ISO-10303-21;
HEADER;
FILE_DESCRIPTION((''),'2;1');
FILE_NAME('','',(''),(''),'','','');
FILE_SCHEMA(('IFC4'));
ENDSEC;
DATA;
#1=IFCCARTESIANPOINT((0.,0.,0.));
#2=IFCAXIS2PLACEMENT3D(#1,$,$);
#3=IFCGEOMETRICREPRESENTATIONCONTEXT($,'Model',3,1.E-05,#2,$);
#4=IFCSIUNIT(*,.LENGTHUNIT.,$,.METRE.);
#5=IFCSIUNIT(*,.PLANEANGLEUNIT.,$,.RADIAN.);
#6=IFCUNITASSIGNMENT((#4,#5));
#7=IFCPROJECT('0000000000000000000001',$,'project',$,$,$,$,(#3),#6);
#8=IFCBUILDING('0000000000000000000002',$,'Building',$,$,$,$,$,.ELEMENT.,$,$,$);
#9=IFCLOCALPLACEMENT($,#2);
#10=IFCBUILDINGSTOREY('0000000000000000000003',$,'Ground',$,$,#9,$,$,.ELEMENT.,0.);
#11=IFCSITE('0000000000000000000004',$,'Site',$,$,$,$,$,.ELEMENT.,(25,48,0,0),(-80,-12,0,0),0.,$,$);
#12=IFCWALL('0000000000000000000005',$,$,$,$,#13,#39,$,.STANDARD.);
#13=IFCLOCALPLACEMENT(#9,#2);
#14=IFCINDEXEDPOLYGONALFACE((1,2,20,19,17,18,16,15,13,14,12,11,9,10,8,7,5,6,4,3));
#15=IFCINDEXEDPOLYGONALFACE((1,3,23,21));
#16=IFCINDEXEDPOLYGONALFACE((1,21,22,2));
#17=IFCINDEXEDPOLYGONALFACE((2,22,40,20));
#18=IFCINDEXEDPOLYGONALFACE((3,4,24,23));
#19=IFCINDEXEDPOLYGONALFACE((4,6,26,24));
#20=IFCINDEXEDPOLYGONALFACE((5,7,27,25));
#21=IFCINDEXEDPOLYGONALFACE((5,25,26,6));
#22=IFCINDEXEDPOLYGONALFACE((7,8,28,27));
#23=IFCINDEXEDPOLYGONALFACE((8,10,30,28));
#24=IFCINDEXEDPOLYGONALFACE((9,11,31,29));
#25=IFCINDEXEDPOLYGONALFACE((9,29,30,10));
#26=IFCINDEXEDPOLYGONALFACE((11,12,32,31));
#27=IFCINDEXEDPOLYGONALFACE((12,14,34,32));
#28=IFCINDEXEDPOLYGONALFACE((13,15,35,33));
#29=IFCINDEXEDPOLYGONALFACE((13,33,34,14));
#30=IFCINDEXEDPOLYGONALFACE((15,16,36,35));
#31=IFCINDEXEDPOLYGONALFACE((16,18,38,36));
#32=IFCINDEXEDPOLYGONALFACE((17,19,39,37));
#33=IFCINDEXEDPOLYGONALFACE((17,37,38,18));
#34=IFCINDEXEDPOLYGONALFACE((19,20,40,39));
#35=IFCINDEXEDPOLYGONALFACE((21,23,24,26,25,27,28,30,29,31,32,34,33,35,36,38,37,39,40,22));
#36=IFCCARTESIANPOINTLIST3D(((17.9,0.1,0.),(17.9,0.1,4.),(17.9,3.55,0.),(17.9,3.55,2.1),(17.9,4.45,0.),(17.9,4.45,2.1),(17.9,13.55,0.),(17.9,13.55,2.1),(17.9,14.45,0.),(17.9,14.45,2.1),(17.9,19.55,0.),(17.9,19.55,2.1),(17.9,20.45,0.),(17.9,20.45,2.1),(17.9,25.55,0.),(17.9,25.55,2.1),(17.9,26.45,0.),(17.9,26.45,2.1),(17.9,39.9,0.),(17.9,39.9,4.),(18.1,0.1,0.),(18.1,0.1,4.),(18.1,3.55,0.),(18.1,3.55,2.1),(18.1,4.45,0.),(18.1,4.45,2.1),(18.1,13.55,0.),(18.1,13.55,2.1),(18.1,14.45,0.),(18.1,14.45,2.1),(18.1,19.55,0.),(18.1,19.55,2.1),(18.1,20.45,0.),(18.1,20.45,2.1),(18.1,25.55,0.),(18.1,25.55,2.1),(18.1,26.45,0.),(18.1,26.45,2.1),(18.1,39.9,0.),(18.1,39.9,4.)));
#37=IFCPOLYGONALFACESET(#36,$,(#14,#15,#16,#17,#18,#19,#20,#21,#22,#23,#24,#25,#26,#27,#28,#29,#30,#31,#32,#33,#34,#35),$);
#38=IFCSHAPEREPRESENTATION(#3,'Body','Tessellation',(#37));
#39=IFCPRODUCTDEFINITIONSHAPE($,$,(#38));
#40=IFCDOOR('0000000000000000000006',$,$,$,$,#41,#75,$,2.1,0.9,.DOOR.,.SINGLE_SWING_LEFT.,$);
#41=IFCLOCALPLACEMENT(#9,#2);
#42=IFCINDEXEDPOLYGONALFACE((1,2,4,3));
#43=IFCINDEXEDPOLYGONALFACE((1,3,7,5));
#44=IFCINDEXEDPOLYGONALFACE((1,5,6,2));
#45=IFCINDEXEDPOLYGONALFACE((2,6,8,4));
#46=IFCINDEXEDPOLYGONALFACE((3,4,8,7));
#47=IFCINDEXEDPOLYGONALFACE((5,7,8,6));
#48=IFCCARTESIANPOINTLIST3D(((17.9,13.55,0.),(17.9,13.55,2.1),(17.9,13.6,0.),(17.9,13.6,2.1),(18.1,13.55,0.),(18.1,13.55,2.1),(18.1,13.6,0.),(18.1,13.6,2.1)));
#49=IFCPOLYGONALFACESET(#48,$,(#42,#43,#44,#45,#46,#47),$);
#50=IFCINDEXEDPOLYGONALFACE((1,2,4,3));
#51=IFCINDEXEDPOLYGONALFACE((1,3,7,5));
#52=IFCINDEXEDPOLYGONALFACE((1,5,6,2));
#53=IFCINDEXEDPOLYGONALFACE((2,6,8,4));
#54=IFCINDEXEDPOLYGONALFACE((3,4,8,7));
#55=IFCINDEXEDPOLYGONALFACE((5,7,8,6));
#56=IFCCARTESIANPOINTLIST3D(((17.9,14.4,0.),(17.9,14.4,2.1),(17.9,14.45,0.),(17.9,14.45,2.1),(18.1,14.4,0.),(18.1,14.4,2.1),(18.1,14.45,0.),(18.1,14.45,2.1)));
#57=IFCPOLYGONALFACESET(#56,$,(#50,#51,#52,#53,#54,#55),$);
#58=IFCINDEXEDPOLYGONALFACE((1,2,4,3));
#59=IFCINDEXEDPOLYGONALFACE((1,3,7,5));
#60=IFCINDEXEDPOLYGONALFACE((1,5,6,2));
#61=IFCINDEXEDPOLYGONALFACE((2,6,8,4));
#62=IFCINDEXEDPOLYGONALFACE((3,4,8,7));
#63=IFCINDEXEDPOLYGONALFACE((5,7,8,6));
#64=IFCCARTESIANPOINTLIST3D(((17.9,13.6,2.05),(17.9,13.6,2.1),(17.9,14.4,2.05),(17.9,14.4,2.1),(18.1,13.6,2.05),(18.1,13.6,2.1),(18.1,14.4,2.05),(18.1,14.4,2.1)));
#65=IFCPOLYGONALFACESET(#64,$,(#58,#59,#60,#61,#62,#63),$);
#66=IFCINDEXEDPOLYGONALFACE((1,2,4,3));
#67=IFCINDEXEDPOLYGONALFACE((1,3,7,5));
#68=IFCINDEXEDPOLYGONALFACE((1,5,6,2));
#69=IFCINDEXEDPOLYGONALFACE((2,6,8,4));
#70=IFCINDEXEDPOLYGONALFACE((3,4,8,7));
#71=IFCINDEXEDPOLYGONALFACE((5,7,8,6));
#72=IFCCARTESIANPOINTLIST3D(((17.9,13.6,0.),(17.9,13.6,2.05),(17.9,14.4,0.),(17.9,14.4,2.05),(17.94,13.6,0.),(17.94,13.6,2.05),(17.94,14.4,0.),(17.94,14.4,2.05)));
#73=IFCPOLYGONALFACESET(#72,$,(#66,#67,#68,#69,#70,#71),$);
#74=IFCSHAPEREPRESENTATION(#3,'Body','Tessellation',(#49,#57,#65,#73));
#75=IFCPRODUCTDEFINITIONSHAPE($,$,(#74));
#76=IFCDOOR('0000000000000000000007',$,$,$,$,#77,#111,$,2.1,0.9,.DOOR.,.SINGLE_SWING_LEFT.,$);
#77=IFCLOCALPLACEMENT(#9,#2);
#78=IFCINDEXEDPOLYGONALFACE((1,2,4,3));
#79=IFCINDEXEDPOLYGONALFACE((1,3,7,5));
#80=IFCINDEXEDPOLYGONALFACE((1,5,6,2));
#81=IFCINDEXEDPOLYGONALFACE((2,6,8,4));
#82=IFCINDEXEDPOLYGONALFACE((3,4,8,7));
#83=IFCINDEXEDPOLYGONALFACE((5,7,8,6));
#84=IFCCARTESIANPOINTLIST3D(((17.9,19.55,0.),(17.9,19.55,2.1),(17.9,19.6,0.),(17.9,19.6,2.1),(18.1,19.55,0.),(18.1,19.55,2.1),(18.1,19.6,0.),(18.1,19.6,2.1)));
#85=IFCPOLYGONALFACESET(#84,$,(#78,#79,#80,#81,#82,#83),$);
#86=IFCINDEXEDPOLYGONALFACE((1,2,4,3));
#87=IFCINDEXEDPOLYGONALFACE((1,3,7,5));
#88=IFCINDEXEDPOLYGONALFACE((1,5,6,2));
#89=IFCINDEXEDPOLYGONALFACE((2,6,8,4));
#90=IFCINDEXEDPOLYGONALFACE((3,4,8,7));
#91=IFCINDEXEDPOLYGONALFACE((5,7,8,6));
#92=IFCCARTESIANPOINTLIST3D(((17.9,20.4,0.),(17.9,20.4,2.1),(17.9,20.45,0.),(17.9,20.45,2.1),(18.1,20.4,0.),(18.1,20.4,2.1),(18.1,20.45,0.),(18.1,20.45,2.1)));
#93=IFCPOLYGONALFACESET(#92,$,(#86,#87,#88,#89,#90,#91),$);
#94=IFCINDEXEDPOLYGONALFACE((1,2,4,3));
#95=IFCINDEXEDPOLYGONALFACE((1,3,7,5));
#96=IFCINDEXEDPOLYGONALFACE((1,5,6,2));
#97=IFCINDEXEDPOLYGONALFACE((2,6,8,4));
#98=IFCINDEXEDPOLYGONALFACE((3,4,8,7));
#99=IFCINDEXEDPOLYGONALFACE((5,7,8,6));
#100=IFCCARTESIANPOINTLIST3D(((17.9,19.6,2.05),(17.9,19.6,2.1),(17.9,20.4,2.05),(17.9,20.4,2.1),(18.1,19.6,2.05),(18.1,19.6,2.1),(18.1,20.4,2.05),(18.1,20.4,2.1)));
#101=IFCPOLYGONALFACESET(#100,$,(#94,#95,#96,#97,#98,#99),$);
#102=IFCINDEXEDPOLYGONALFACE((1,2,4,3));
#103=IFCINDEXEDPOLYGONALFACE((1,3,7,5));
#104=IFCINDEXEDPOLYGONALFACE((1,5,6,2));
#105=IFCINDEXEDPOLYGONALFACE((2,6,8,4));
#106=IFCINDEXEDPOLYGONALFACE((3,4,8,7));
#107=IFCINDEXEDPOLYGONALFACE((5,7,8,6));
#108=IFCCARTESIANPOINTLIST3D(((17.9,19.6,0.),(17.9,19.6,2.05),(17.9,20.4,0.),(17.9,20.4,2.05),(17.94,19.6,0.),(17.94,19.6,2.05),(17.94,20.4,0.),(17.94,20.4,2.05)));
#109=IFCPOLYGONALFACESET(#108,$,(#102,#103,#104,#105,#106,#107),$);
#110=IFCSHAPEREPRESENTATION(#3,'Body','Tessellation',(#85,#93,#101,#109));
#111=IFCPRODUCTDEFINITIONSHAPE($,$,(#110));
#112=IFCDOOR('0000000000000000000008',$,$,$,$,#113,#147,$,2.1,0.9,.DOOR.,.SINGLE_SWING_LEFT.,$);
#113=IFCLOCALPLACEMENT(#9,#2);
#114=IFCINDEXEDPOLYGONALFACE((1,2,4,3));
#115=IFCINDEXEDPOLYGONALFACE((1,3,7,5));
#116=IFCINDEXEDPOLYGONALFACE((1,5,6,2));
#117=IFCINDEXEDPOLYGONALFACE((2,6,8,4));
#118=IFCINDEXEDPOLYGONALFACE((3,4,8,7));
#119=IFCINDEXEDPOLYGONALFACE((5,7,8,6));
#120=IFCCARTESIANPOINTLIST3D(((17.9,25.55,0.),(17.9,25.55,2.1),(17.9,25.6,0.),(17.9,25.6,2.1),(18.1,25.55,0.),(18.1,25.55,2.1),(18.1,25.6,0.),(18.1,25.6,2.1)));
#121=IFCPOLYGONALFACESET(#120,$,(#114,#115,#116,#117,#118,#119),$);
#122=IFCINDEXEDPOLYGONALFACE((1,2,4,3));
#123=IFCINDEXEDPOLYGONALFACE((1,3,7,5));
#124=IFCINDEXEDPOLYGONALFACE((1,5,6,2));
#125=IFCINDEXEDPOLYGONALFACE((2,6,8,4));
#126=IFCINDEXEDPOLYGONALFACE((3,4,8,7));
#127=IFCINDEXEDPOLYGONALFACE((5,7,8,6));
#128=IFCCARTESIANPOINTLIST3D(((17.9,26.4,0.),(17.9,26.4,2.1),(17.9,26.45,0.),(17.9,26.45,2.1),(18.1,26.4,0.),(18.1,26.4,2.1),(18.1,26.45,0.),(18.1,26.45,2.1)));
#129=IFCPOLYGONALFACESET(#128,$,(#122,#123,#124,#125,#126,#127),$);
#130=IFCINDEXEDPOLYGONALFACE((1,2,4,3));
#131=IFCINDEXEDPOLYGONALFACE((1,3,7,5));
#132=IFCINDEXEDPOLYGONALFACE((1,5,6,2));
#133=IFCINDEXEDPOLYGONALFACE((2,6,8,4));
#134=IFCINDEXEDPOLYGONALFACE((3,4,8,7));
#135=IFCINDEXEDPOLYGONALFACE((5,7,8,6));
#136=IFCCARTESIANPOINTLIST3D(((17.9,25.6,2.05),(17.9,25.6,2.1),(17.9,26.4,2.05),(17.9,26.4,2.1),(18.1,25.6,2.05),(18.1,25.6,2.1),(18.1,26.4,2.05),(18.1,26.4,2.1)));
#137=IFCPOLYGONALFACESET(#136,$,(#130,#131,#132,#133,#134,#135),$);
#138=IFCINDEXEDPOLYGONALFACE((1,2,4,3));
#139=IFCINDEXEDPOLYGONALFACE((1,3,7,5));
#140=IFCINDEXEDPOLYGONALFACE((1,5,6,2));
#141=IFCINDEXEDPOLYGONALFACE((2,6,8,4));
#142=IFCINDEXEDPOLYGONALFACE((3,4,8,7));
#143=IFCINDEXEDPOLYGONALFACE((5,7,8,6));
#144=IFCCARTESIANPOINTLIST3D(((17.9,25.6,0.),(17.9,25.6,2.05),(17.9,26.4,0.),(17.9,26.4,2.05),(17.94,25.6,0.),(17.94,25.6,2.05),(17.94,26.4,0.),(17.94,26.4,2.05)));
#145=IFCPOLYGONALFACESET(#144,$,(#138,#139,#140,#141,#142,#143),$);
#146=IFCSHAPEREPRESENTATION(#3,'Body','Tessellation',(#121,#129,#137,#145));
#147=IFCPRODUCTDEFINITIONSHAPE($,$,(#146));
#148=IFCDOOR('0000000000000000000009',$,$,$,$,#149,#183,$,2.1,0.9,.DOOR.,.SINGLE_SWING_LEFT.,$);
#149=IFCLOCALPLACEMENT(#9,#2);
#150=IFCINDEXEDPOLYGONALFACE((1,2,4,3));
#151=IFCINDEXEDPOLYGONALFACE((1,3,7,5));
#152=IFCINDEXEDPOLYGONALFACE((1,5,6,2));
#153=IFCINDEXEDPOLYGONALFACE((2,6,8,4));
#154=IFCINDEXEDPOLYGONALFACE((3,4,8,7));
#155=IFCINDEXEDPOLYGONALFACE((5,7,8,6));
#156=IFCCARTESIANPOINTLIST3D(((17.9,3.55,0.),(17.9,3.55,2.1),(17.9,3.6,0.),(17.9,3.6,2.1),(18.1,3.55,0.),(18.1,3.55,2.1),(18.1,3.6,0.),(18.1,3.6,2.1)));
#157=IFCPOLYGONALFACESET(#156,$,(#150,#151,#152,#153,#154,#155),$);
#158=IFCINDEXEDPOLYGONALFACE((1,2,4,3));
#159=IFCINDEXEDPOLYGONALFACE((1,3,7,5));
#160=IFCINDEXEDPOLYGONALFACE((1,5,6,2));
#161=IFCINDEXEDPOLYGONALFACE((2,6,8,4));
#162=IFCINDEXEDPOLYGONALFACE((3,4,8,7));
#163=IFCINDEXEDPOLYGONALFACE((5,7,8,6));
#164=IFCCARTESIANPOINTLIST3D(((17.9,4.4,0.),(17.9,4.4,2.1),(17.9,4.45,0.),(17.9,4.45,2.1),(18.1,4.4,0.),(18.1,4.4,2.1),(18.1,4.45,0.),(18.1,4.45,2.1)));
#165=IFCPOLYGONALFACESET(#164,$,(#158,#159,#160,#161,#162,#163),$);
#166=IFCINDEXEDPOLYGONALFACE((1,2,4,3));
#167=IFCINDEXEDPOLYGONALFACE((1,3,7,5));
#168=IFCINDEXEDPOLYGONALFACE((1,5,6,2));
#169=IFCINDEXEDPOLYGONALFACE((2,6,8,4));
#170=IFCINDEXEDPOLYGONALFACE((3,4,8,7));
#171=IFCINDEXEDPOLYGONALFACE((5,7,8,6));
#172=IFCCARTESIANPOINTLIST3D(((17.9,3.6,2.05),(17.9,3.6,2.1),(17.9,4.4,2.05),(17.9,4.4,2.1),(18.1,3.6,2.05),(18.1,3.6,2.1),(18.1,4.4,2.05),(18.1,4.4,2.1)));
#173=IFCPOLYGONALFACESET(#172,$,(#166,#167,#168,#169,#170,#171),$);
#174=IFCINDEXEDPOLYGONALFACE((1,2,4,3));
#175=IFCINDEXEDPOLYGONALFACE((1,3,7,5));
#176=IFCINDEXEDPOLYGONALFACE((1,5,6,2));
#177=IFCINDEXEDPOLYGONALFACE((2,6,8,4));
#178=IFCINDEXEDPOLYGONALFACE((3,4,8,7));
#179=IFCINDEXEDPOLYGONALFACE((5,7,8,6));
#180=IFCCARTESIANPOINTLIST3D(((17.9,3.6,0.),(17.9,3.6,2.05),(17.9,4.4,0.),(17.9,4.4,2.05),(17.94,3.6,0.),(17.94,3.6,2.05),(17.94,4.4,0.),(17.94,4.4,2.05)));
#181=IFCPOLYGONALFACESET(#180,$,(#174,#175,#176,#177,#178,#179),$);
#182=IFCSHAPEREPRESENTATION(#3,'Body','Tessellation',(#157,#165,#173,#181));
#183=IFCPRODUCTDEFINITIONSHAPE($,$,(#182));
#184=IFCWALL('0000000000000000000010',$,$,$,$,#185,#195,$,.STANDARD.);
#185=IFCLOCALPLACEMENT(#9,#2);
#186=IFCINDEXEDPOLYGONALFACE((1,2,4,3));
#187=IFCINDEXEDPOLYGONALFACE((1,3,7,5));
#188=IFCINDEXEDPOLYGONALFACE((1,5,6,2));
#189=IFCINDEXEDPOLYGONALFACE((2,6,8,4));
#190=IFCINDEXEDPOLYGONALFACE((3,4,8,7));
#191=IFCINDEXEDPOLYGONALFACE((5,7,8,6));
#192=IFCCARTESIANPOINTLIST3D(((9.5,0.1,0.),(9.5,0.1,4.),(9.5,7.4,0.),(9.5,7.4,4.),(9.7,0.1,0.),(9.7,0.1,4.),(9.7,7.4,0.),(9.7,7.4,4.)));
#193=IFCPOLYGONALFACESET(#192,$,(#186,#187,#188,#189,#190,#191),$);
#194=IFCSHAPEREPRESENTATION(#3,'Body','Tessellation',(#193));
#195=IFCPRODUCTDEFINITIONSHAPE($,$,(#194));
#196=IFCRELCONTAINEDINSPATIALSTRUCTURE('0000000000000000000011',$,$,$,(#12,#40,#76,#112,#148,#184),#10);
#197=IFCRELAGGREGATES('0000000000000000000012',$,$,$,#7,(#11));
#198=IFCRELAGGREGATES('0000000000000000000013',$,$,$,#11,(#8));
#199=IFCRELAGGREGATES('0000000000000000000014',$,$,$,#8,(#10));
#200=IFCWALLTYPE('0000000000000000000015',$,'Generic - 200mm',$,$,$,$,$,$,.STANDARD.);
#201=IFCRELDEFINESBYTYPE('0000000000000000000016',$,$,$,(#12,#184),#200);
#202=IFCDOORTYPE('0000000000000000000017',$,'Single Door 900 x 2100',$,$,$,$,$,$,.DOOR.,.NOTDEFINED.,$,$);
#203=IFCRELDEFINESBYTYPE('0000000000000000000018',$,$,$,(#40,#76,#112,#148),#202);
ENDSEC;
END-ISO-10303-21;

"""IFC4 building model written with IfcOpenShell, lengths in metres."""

from ifc_helpers import new_model, si_unit, frame, frame_2d, origin, origin_with_axes, origin_2d, place, context, project, spatial, polyline, rectangle, outline, extrude, type_object, element, fill, save


model = new_model("IFC4")

# Units and contexts
model_context = context("Model", 3, precision=1e-05, world=origin())
ifc_project = project(units=[si_unit("LENGTHUNIT", "METRE"), si_unit("PLANEANGLEUNIT", "RADIAN")], contexts=[model_context])

# Site, building, storey
site = spatial("IfcSite", under=ifc_project, Name="Site", CompositionType="ELEMENT", RefLatitude=(25, 48, 0, 0), RefLongitude=(-80, -12, 0, 0), RefElevation=0.0)
building = spatial("IfcBuilding", under=site, Name="Building", CompositionType="ELEMENT")
storey_placement = place(None, origin())
storey = spatial("IfcBuildingStorey", under=building, at=storey_placement, Name="Ground", CompositionType="ELEMENT", Elevation=0.0)

# Wall, openings, doors
wall_type_1 = type_object("IfcWallType", Name="Generic - 200mm", PredefinedType="STANDARD")
door_type = type_object("IfcDoorType", Name="Single Door 900 x 2100", OperationType="NOTDEFINED", PredefinedType="DOOR")
wall_1_placement = place(None, frame((18.0, 0.0, 0.0), z_axis=(0.0, 0.0, 1.0), x_axis=(0.0, 1.0, 0.0)))
wall_1 = element("IfcWall", 1, at=wall_1_placement, inside=storey, type_object=wall_type_1, PredefinedType="STANDARD", context=model_context, shape_type="SweptSolid", body=[
    extrude(outline(polyline([(0.1, -0.1), (39.9, -0.1), (39.9, 0.1), (0.1, 0.1), (0.1, -0.1)])), origin(), (0.0, 0.0, 1.0), 4.0),
])
opening_1_placement = place(wall_1_placement, frame((14.0, 0.0, 0.0), z_axis=(0.0, 0.0, 1.0), x_axis=(1.0, 0.0, 0.0)))
opening_1 = element("IfcOpeningElement", 2, at=opening_1_placement, cuts=wall_1, PredefinedType="OPENING", context=model_context, shape_type="SweptSolid", body=[
    extrude(rectangle(XDim=0.9, YDim=0.202, at=origin_2d()), origin(), (0.0, 0.0, 1.0), 2.1),
])
opening_2_placement = place(wall_1_placement, frame((20.0, 0.0, 0.0), z_axis=(0.0, 0.0, 1.0), x_axis=(1.0, 0.0, 0.0)))
opening_2 = element("IfcOpeningElement", 3, at=opening_2_placement, cuts=wall_1, PredefinedType="OPENING", context=model_context, shape_type="SweptSolid", body=[
    extrude(rectangle(XDim=0.9, YDim=0.202, at=origin_2d()), origin(), (0.0, 0.0, 1.0), 2.1),
])
opening_3_placement = place(wall_1_placement, frame((26.0, 0.0, 0.0), z_axis=(0.0, 0.0, 1.0), x_axis=(1.0, 0.0, 0.0)))
opening_3 = element("IfcOpeningElement", 4, at=opening_3_placement, cuts=wall_1, PredefinedType="OPENING", context=model_context, shape_type="SweptSolid", body=[
    extrude(rectangle(XDim=0.9, YDim=0.202, at=origin_2d()), origin(), (0.0, 0.0, 1.0), 2.1),
])
opening_4_placement = place(wall_1_placement, frame((4.0, 0.0, 0.0), z_axis=(0.0, 0.0, 1.0), x_axis=(1.0, 0.0, 0.0)))
opening_4 = element("IfcOpeningElement", 5, at=opening_4_placement, cuts=wall_1, PredefinedType="OPENING", context=model_context, shape_type="SweptSolid", body=[
    extrude(rectangle(XDim=0.9, YDim=0.202, at=origin_2d()), origin(), (0.0, 0.0, 1.0), 2.1),
])
door_1_placement = place(opening_1_placement, origin_with_axes())
door_1 = element("IfcDoor", 6, at=door_1_placement, inside=storey, type_object=door_type, OperationType="SINGLE_SWING_LEFT", OverallHeight=2.1, OverallWidth=0.9, PredefinedType="DOOR", context=model_context, shape_type="SweptSolid", body=[
    extrude(rectangle(XDim=0.05, YDim=0.2, at=frame_2d((-0.425, 0.0))), origin(), (0.0, 0.0, 1.0), 2.1),
    extrude(rectangle(XDim=0.05, YDim=0.2, at=frame_2d((0.425, 0.0))), origin(), (0.0, 0.0, 1.0), 2.1),
    extrude(rectangle(XDim=0.8, YDim=0.2, at=origin_2d()), frame((0.0, 0.0, 2.05)), (0.0, 0.0, 1.0), 0.05),
    extrude(rectangle(XDim=0.8, YDim=0.04, at=frame_2d((0.0, 0.08))), origin(), (0.0, 0.0, 1.0), 2.05),
])
fill(opening_1, door_1)
door_2_placement = place(opening_2_placement, origin_with_axes())
door_2 = element("IfcDoor", 7, at=door_2_placement, inside=storey, type_object=door_type, OperationType="SINGLE_SWING_LEFT", OverallHeight=2.1, OverallWidth=0.9, PredefinedType="DOOR", context=model_context, shape_type="SweptSolid", body=[
    extrude(rectangle(XDim=0.05, YDim=0.2, at=frame_2d((-0.425, 0.0))), origin(), (0.0, 0.0, 1.0), 2.1),
    extrude(rectangle(XDim=0.05, YDim=0.2, at=frame_2d((0.425, 0.0))), origin(), (0.0, 0.0, 1.0), 2.1),
    extrude(rectangle(XDim=0.8, YDim=0.2, at=origin_2d()), frame((0.0, 0.0, 2.05)), (0.0, 0.0, 1.0), 0.05),
    extrude(rectangle(XDim=0.8, YDim=0.04, at=frame_2d((0.0, 0.08))), origin(), (0.0, 0.0, 1.0), 2.05),
])
fill(opening_2, door_2)
door_3_placement = place(opening_3_placement, origin_with_axes())
door_3 = element("IfcDoor", 8, at=door_3_placement, inside=storey, type_object=door_type, OperationType="SINGLE_SWING_LEFT", OverallHeight=2.1, OverallWidth=0.9, PredefinedType="DOOR", context=model_context, shape_type="SweptSolid", body=[
    extrude(rectangle(XDim=0.05, YDim=0.2, at=frame_2d((-0.425, 0.0))), origin(), (0.0, 0.0, 1.0), 2.1),
    extrude(rectangle(XDim=0.05, YDim=0.2, at=frame_2d((0.425, 0.0))), origin(), (0.0, 0.0, 1.0), 2.1),
    extrude(rectangle(XDim=0.8, YDim=0.2, at=origin_2d()), frame((0.0, 0.0, 2.05)), (0.0, 0.0, 1.0), 0.05),
    extrude(rectangle(XDim=0.8, YDim=0.04, at=frame_2d((0.0, 0.08))), origin(), (0.0, 0.0, 1.0), 2.05),
])
fill(opening_3, door_3)
door_4_placement = place(opening_4_placement, origin_with_axes())
door_4 = element("IfcDoor", 9, at=door_4_placement, inside=storey, type_object=door_type, OperationType="SINGLE_SWING_LEFT", OverallHeight=2.1, OverallWidth=0.9, PredefinedType="DOOR", context=model_context, shape_type="SweptSolid", body=[
    extrude(rectangle(XDim=0.05, YDim=0.2, at=frame_2d((-0.425, 0.0))), origin(), (0.0, 0.0, 1.0), 2.1),
    extrude(rectangle(XDim=0.05, YDim=0.2, at=frame_2d((0.425, 0.0))), origin(), (0.0, 0.0, 1.0), 2.1),
    extrude(rectangle(XDim=0.8, YDim=0.2, at=origin_2d()), frame((0.0, 0.0, 2.05)), (0.0, 0.0, 1.0), 0.05),
    extrude(rectangle(XDim=0.8, YDim=0.04, at=frame_2d((0.0, 0.08))), origin(), (0.0, 0.0, 1.0), 2.05),
])
fill(opening_4, door_4)

# Wall
wall_2_placement = place(None, frame((9.6, 0.0, 0.0), z_axis=(0.0, 0.0, 1.0), x_axis=(0.0, 1.0, 0.0)))
element("IfcWall", 10, at=wall_2_placement, inside=storey, type_object=wall_type_1, PredefinedType="STANDARD", context=model_context, shape_type="SweptSolid", body=[
    extrude(outline(polyline([(0.1, -0.1), (7.4, -0.1), (7.4, 0.1), (0.1, 0.1), (0.1, -0.1)])), origin(), (0.0, 0.0, 1.0), 4.0),
])

save(model, "model.ifc")
